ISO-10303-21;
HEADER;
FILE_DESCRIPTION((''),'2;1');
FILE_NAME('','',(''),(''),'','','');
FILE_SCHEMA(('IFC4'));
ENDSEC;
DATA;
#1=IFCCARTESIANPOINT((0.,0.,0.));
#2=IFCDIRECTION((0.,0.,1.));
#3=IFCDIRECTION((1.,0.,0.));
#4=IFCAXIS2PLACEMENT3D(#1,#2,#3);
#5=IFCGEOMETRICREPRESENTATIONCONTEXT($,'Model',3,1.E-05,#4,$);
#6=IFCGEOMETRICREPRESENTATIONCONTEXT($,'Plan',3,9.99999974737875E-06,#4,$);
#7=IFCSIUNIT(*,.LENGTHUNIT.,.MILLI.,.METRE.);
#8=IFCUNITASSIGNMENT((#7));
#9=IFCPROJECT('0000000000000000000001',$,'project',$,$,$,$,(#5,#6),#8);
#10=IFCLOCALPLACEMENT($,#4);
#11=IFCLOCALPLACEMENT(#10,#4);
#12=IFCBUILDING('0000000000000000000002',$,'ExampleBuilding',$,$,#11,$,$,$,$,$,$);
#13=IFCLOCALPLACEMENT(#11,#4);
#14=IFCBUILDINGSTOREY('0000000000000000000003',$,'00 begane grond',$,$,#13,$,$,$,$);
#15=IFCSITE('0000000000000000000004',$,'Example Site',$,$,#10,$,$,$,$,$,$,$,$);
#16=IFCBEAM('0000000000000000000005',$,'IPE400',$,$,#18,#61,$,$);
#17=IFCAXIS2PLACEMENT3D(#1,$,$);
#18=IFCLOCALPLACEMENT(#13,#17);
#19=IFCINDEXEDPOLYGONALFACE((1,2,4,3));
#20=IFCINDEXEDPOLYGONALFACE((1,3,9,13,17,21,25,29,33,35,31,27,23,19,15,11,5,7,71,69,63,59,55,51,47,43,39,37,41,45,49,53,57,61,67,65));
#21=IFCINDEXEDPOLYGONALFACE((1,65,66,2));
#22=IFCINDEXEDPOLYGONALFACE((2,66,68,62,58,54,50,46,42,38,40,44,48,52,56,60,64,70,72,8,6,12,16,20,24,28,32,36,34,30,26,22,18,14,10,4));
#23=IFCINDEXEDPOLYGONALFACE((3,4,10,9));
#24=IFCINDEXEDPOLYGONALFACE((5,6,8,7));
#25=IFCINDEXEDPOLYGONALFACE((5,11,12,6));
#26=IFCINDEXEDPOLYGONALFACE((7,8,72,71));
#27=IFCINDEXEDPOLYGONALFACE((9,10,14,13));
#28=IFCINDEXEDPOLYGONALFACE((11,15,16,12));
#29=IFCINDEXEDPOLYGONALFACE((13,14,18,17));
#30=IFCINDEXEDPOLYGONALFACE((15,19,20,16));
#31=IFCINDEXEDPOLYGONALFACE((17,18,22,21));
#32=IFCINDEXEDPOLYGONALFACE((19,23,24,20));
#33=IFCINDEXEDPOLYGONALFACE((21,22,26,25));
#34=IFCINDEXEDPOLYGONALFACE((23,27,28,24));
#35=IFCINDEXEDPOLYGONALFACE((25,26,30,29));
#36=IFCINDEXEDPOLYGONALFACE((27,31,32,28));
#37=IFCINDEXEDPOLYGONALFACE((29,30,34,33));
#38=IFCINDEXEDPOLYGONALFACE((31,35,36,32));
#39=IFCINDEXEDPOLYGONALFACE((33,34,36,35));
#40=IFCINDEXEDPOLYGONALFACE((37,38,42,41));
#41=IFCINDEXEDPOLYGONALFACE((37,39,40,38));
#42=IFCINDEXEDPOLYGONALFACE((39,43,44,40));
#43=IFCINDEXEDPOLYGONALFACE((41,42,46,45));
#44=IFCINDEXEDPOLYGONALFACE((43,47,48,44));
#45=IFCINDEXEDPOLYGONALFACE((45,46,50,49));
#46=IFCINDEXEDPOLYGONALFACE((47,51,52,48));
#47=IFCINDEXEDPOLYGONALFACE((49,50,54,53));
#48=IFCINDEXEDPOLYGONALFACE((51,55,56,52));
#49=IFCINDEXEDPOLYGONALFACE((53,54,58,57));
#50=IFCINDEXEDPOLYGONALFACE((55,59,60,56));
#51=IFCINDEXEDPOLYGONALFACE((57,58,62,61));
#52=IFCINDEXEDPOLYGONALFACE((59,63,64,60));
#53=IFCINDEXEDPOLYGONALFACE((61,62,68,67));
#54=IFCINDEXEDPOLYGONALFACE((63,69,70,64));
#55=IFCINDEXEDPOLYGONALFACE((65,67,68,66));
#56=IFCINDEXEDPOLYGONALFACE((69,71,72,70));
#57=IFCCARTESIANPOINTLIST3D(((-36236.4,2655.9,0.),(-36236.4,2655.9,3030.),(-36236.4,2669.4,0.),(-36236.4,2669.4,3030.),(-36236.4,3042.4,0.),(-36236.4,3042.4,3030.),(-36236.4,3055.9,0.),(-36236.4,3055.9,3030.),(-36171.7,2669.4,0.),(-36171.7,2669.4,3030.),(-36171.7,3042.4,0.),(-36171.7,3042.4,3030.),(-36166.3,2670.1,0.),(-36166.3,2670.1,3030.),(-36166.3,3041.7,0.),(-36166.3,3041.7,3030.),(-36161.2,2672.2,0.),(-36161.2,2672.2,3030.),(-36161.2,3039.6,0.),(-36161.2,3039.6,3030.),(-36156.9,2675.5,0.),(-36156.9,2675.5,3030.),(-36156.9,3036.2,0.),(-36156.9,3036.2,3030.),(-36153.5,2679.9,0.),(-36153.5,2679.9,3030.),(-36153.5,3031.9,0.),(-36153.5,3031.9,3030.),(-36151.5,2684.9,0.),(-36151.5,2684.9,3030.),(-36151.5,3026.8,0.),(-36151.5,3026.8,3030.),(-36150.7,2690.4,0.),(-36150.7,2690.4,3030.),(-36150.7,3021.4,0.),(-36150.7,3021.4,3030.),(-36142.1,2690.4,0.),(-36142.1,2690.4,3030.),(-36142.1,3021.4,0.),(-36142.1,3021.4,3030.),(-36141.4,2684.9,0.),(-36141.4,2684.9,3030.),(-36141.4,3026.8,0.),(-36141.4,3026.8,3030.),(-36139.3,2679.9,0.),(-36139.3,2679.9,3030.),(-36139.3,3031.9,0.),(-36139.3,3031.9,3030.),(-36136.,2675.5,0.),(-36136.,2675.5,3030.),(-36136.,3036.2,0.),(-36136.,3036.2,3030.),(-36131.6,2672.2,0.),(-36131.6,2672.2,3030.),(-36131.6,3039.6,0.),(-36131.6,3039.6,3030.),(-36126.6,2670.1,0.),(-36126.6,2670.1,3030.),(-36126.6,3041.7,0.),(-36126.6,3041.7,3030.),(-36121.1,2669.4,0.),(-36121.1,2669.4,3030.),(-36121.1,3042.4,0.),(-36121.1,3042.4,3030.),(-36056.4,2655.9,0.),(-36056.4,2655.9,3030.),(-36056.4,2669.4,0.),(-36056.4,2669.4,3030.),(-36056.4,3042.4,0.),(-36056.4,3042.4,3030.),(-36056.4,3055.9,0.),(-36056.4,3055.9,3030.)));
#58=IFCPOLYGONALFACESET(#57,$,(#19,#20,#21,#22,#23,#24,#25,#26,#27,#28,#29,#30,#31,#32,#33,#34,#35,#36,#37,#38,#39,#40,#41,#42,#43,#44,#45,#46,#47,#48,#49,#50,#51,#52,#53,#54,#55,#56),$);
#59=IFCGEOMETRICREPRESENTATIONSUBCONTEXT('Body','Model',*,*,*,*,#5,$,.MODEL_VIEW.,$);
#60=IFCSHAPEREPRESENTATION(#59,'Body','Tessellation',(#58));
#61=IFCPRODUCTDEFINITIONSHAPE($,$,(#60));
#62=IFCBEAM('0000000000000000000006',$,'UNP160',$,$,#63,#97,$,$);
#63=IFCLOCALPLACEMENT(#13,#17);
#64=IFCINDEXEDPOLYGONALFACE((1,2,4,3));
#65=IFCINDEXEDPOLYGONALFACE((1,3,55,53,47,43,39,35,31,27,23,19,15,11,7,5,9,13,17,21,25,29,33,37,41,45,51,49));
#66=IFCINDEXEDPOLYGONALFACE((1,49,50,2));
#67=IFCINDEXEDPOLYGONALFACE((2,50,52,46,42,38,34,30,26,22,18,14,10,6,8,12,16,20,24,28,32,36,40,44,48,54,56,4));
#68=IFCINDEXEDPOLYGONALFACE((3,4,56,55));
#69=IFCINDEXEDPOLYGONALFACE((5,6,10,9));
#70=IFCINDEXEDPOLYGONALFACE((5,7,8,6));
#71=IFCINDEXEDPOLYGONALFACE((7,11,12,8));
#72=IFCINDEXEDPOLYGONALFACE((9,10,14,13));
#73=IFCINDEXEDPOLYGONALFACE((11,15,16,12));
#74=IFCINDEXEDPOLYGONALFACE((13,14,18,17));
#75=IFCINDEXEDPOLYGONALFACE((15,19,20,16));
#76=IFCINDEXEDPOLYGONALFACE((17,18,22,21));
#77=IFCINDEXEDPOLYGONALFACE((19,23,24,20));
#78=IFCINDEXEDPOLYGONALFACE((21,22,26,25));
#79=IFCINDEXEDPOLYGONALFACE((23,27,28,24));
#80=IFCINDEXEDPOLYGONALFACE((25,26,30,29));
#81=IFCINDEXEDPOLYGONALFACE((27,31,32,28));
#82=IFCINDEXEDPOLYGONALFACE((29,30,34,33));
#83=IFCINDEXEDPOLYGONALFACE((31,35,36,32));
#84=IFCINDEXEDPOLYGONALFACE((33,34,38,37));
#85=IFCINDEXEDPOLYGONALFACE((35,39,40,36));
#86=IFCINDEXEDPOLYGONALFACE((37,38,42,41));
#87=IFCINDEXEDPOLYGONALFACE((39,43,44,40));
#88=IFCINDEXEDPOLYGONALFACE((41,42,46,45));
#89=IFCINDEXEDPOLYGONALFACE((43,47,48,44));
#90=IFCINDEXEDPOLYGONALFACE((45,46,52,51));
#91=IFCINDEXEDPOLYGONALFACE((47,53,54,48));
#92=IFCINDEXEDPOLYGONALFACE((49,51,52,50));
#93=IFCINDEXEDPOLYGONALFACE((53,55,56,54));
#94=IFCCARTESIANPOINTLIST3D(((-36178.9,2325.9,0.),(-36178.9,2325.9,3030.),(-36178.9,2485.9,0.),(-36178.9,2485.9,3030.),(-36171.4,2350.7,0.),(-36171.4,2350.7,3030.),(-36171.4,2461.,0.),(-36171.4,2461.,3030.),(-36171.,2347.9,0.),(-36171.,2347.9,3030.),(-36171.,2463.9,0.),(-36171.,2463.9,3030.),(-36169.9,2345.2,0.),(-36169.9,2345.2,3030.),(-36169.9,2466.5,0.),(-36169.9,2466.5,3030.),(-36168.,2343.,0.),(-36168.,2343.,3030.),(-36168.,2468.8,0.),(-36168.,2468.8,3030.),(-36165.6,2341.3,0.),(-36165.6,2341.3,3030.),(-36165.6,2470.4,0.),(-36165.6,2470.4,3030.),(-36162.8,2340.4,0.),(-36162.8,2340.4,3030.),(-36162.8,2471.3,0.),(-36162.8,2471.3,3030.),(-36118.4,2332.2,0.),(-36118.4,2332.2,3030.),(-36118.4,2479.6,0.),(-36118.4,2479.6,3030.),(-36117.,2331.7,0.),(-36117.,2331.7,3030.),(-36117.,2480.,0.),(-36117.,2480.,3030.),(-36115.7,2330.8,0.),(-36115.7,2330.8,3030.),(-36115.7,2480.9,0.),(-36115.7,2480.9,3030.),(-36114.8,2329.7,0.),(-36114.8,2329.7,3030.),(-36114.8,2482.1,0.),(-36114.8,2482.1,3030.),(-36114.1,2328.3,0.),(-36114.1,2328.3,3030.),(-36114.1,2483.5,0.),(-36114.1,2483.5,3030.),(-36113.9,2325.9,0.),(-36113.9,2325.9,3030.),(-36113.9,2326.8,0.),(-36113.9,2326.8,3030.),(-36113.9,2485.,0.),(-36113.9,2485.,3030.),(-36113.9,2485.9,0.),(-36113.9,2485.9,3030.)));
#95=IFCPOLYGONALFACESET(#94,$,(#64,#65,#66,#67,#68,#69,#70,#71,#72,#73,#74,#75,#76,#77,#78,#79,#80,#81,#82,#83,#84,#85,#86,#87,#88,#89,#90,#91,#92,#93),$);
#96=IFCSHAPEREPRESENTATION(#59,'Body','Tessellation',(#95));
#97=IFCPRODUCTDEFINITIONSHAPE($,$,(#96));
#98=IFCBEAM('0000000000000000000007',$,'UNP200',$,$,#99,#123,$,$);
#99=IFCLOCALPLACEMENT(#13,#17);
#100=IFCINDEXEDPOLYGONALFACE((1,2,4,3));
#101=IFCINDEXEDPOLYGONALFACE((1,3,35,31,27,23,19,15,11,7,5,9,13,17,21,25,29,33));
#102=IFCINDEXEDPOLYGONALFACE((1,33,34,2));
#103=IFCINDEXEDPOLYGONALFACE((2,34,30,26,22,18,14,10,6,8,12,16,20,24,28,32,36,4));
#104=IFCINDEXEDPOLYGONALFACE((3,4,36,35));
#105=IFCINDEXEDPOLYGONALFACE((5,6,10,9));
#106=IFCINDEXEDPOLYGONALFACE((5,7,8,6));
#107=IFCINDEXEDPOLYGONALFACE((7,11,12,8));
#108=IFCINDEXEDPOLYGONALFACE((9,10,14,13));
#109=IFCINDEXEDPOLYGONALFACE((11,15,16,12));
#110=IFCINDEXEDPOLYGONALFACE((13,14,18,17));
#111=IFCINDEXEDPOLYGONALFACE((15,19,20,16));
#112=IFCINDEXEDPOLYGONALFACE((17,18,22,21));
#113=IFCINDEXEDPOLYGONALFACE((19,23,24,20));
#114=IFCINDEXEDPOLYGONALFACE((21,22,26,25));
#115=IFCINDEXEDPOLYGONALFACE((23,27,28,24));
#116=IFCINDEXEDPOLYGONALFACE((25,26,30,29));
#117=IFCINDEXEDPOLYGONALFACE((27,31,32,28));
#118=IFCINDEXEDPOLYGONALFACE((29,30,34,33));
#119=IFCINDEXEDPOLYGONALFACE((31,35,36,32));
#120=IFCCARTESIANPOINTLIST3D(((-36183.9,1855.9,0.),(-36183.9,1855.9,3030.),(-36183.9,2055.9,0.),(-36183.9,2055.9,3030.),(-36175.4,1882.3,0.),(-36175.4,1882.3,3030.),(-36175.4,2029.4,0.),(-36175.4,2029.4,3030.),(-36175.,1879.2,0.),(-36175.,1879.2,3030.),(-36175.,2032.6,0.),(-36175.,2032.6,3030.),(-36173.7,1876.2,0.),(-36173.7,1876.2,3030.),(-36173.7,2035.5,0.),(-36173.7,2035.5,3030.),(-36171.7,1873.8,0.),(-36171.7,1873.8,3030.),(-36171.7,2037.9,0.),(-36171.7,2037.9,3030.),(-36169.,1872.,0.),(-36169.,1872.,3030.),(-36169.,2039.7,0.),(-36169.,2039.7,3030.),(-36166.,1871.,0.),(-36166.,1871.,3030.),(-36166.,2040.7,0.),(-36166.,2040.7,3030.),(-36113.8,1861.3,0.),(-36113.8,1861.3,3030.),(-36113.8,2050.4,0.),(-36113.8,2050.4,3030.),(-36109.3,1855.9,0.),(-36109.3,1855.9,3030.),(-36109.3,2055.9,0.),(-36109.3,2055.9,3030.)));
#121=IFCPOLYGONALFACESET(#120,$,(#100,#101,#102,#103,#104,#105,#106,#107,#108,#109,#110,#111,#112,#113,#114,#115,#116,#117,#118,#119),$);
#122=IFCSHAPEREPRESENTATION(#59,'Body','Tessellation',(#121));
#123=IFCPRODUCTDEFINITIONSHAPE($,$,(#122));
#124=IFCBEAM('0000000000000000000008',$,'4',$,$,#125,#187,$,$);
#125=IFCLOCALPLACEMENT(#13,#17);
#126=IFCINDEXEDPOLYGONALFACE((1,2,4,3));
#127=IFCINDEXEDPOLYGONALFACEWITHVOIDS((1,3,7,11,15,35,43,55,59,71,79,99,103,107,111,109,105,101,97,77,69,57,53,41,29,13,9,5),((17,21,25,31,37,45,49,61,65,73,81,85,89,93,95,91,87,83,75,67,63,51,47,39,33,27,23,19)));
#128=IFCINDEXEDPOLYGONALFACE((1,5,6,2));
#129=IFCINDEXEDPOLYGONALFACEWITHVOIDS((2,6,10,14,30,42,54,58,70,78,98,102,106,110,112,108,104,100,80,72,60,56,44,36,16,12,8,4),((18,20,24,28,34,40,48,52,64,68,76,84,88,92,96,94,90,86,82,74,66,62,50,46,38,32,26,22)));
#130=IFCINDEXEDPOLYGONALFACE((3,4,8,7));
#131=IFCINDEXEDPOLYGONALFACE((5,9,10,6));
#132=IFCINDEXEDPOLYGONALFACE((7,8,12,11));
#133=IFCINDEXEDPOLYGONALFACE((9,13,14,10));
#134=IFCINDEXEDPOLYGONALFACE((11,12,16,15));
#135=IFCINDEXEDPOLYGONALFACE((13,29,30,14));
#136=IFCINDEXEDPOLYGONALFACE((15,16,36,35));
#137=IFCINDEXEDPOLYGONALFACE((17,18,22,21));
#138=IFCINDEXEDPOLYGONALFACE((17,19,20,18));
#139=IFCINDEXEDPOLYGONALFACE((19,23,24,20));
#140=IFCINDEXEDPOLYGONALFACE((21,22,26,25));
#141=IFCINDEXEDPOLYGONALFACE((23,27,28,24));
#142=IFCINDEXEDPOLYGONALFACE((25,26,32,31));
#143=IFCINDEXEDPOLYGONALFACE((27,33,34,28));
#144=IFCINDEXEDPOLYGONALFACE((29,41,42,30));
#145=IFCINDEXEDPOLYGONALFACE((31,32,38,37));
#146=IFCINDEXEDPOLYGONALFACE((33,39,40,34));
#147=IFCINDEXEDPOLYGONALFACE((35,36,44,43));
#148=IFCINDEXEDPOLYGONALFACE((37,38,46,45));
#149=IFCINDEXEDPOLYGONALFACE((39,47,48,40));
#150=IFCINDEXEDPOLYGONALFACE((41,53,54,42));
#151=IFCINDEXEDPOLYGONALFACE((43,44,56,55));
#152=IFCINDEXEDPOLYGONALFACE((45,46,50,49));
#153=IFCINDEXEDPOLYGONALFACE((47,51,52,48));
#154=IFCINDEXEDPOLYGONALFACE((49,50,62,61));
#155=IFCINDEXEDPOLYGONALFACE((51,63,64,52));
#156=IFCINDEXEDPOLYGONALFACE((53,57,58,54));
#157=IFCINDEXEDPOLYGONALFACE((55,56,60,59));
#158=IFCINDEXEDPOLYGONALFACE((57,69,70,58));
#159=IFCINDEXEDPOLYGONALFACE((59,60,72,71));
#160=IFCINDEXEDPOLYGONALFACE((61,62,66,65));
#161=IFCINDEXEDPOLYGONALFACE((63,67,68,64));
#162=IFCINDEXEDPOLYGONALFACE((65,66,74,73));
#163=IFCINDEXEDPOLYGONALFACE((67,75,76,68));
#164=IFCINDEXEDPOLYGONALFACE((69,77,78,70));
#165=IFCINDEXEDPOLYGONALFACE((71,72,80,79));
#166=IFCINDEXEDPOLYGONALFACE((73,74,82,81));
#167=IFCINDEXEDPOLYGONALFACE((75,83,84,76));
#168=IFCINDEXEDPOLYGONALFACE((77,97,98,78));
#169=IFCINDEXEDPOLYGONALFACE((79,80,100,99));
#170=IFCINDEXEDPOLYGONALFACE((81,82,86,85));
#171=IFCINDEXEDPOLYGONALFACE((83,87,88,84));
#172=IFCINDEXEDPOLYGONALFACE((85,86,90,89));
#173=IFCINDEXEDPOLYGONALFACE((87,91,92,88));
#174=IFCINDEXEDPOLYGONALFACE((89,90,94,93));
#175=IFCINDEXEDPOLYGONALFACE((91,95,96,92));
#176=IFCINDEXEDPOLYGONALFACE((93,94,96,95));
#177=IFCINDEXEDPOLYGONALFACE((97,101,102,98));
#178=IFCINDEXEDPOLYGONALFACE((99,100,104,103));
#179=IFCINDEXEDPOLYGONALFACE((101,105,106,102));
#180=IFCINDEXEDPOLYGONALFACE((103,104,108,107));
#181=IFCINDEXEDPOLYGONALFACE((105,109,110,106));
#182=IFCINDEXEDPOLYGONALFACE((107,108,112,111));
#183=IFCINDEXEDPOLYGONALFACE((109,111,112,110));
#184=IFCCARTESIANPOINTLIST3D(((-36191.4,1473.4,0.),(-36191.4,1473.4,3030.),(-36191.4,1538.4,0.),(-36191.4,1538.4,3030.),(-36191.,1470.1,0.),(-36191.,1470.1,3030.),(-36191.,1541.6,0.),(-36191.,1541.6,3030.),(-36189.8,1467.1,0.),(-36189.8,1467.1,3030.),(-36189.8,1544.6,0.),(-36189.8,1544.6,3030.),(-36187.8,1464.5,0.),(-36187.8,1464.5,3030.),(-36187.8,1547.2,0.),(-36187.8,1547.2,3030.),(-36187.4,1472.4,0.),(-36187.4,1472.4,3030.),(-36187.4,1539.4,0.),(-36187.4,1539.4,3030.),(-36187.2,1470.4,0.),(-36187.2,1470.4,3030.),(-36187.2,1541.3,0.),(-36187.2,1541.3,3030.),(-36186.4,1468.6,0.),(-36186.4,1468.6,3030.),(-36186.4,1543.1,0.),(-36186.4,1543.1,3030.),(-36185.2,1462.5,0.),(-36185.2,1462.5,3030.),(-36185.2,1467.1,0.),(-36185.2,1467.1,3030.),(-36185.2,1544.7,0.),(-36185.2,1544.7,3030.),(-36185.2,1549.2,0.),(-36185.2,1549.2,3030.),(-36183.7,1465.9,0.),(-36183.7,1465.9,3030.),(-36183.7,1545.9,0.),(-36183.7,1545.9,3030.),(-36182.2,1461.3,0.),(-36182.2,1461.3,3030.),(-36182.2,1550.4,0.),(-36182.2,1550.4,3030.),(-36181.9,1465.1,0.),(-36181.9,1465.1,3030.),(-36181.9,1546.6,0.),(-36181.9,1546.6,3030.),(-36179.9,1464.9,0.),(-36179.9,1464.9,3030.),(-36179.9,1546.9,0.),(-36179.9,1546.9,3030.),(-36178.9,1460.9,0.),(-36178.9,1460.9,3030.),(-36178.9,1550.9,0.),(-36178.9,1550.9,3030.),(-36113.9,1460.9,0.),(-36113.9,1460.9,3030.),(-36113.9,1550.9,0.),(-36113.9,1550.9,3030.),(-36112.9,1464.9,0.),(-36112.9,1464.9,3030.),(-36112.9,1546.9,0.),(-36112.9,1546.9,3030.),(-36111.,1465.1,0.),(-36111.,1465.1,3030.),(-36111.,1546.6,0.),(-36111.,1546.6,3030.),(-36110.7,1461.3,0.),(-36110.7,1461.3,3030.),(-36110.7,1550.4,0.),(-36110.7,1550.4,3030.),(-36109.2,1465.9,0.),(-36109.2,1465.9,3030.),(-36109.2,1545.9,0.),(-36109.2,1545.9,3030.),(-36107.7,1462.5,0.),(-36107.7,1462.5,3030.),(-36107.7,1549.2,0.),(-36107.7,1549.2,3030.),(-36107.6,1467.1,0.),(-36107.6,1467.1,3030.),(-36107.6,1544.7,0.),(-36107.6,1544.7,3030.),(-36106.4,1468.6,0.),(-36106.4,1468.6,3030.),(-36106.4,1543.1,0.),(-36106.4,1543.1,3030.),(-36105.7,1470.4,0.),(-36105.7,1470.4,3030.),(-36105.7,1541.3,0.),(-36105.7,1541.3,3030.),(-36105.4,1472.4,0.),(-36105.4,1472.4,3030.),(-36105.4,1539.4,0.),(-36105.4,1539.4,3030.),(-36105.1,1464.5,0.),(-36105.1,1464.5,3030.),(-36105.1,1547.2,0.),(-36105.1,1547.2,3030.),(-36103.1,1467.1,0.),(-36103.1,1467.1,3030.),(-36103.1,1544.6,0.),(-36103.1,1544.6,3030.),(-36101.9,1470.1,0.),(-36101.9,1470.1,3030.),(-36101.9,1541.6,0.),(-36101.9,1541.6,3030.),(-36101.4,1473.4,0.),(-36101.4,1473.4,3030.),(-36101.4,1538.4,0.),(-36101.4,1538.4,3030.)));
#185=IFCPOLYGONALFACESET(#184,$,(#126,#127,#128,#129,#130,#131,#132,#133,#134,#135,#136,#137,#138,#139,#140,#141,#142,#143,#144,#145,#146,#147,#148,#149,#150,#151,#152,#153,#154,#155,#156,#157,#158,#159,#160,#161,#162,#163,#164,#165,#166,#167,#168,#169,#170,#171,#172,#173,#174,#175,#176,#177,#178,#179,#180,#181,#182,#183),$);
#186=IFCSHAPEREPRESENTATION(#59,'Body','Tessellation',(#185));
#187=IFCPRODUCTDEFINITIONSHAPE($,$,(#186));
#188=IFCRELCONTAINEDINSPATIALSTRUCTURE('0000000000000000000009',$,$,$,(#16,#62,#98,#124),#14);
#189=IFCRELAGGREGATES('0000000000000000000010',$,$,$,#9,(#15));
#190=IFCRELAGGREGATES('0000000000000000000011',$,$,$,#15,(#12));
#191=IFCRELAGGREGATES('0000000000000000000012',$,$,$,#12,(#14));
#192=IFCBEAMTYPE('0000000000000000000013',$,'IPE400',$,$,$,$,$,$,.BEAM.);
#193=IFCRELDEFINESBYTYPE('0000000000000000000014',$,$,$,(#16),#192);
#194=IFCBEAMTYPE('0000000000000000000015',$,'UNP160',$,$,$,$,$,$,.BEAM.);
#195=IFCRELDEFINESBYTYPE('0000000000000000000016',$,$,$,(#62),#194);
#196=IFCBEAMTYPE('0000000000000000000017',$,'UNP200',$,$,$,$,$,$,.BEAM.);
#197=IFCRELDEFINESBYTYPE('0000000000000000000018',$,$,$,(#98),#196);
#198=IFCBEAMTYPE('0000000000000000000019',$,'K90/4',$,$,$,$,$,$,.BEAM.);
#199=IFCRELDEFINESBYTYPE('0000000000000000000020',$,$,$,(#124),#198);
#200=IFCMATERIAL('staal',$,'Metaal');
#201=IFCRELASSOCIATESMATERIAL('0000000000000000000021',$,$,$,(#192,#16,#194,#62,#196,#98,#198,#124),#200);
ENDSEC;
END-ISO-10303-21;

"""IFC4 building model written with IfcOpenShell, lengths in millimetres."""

from ifc_helpers import new_model, si_unit, frame, origin_with_axes, place, context, subcontext, project, spatial, hollow_rectangle, i_section, u_section, extrude, material, material_profile, profile_set, profile_usage, type_object, element, save


model = new_model("IFC4")

# Units and contexts
model_context = context("Model", 3, precision=1e-05, world=origin_with_axes())
plan_context = context("Plan", 3, precision=9.99999974737875e-06, world=origin_with_axes())
body_context = subcontext(model_context, "Body", "Model", "MODEL_VIEW")
ifc_project = project(units=[si_unit("LENGTHUNIT", "METRE", prefix="MILLI")], contexts=[model_context, plan_context])

# Site, building, storey
site_placement = place(None, frame((0.0, 0.0, 0.0), z_axis=(0.0, 0.0, 1.0), x_axis=(1.0, 0.0, 0.0)))
site = spatial("IfcSite", under=ifc_project, at=site_placement, Name="Example Site")
building_placement = place(site_placement, frame((0.0, 0.0, 0.0), z_axis=(0.0, 0.0, 1.0), x_axis=(1.0, 0.0, 0.0)))
building = spatial("IfcBuilding", under=site, at=building_placement, Name="ExampleBuilding")
storey_placement = place(building_placement, frame((0.0, 0.0, 0.0), z_axis=(0.0, 0.0, 1.0), x_axis=(1.0, 0.0, 0.0)))
storey = spatial("IfcBuildingStorey", under=building, at=storey_placement, Name="00 begane grond")

# Beams
ifc_material_1 = material(Name="staal", Category="Metaal")
ifc_material_profile_1 = material_profile(ifc_material_1, i_section(OverallWidth=180.0, OverallDepth=400.0, WebThickness=8.6, FlangeThickness=13.5, FilletRadius=21.0))
ifc_profile_set_1 = profile_set([ifc_material_profile_1], Name="staal")
ifc_profile_usage_1 = profile_usage(ifc_profile_set_1, cardinal=5)
beam_type_1 = type_object("IfcBeamType", Name="IPE400", PredefinedType="BEAM", material=ifc_profile_set_1)
beam_1_placement = place(storey_placement, frame((-36146.4, 2855.9, 0.0), z_axis=(-0.000001, 0.0, 1.0), x_axis=(1.0, 0.0, 0.000001)))
element("IfcBeam", 1, at=beam_1_placement, inside=storey, type_object=beam_type_1, material=ifc_profile_usage_1, Name="IPE400", context=body_context, shape_type="SweptSolid", body=[
    extrude(i_section(OverallWidth=180.0, OverallDepth=400.0, WebThickness=8.6, FlangeThickness=13.5, FilletRadius=21.0), origin_with_axes(), (0.0, 0.0, 1.0), 3030.0),
])
ifc_material_profile_2 = material_profile(ifc_material_1, u_section(Depth=160.0, FlangeWidth=65.0, WebThickness=7.5, FlangeThickness=11.5, FilletRadius=10.5, EdgeRadius=5.5, FlangeSlope=6.1, kind="CURVE"))
ifc_profile_set_2 = profile_set([ifc_material_profile_2], Name="staal")
ifc_profile_usage_2 = profile_usage(ifc_profile_set_2)
beam_type_2 = type_object("IfcBeamType", Name="UNP160", PredefinedType="BEAM", material=ifc_profile_set_2)
beam_2_placement = place(storey_placement, frame((-36146.4, 2405.9, 0.0), z_axis=(-0.000001, 0.0, 1.0), x_axis=(1.0, 0.0, 0.000001)))
element("IfcBeam", 2, at=beam_2_placement, inside=storey, type_object=beam_type_2, material=ifc_profile_usage_2, Name="UNP160", context=body_context, shape_type="SweptSolid", body=[
    extrude(u_section(Depth=160.0, FlangeWidth=65.0, WebThickness=7.5, FlangeThickness=11.5, FilletRadius=10.5, EdgeRadius=5.5, FlangeSlope=6.1, kind="CURVE"), origin_with_axes(), (0.0, 0.0, 1.0), 3030.0),
])
ifc_material_profile_3 = material_profile(ifc_material_1, u_section(Depth=200.0, FlangeWidth=75.0, WebThickness=8.5, FlangeThickness=11.5, FilletRadius=11.5, EdgeRadius=6.0, FlangeSlope=6.1, kind="CURVE"))
ifc_profile_set_3 = profile_set([ifc_material_profile_3], Name="staal")
ifc_profile_usage_3 = profile_usage(ifc_profile_set_3)
beam_type_3 = type_object("IfcBeamType", Name="UNP200", PredefinedType="BEAM", material=ifc_profile_set_3)
beam_3_placement = place(storey_placement, frame((-36146.4, 1955.9, 0.0), z_axis=(-0.000001, 0.0, 1.0), x_axis=(1.0, 0.0, 0.000001)))
element("IfcBeam", 3, at=beam_3_placement, inside=storey, type_object=beam_type_3, material=ifc_profile_usage_3, Name="UNP200", context=body_context, shape_type="SweptSolid", body=[
    extrude(u_section(Depth=200.0, FlangeWidth=75.0, WebThickness=8.5, FlangeThickness=11.5, FilletRadius=11.5, EdgeRadius=6.0, FlangeSlope=6.1, kind="CURVE"), origin_with_axes(), (0.0, 0.0, 1.0), 3030.0),
])
ifc_material_profile_4 = material_profile(ifc_material_1, hollow_rectangle(XDim=90.0, YDim=90.0, WallThickness=4.0, InnerFilletRadius=7.5, OuterFilletRadius=12.5))
ifc_profile_set_4 = profile_set([ifc_material_profile_4], Name="staal")
ifc_profile_usage_4 = profile_usage(ifc_profile_set_4)
beam_type_4 = type_object("IfcBeamType", Name="K90/4", PredefinedType="BEAM", material=ifc_profile_set_4)
beam_4_placement = place(storey_placement, frame((-36146.4, 1505.9, 0.0), z_axis=(-0.000001, 0.0, 1.0), x_axis=(1.0, 0.0, 0.000001)))
element("IfcBeam", 4, at=beam_4_placement, inside=storey, type_object=beam_type_4, material=ifc_profile_usage_4, Name="4", context=body_context, shape_type="SweptSolid", body=[
    extrude(hollow_rectangle(XDim=90.0, YDim=90.0, WallThickness=4.0, InnerFilletRadius=7.5, OuterFilletRadius=12.5), origin_with_axes(), (0.0, 0.0, 1.0), 3030.0),
])

save(model, "model.ifc")
